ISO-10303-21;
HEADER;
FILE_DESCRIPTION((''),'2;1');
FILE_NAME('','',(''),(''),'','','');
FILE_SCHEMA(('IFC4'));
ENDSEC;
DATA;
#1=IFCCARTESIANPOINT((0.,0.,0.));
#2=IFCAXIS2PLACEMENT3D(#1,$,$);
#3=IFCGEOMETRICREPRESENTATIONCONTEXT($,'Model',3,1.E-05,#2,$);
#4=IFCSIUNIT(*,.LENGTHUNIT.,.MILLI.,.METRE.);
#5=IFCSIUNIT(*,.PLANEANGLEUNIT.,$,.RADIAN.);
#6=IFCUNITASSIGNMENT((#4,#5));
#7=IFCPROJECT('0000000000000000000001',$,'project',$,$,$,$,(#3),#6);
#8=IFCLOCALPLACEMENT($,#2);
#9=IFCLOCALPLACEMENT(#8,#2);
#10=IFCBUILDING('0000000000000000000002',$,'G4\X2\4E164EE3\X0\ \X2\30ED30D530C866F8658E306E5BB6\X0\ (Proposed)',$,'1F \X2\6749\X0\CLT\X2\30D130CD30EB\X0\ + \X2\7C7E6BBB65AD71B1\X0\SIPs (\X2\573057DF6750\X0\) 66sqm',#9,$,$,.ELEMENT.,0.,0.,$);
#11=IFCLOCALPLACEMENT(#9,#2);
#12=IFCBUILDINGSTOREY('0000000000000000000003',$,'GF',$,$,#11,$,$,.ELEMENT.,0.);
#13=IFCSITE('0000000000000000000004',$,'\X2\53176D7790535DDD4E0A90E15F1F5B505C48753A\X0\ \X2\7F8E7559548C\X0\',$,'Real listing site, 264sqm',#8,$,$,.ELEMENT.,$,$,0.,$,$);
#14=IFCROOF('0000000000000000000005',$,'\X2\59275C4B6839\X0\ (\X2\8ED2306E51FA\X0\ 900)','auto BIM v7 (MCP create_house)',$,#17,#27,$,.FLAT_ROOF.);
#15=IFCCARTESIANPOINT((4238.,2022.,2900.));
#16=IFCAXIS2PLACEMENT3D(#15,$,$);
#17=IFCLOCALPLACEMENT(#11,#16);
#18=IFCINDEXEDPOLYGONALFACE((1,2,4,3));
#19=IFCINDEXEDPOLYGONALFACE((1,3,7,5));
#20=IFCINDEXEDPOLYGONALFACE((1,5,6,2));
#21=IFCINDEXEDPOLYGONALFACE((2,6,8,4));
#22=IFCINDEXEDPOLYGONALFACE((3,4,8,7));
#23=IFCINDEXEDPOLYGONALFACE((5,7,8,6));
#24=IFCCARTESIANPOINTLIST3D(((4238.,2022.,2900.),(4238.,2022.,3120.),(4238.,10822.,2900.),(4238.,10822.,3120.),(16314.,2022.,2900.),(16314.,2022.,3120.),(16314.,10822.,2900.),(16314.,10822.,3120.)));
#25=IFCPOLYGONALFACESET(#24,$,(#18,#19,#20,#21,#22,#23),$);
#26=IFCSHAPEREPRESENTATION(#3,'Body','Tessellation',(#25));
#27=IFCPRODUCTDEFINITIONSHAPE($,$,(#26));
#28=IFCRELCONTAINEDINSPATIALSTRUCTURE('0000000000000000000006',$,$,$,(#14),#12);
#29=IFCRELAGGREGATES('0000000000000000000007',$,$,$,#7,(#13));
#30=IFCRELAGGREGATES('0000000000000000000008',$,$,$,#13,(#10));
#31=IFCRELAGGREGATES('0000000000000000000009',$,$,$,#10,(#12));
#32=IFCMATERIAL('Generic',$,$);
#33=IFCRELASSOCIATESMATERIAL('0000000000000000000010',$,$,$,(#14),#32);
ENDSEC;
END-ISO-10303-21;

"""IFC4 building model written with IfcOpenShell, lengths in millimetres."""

from ifc_helpers import new_model, si_unit, frame, frame_2d, origin, place, context, project, spatial, rectangle, extrude, material, element, save


model = new_model("IFC4")

# Units and contexts
model_context = context("Model", 3, precision=1e-05, world=origin())
ifc_project = project(units=[si_unit("LENGTHUNIT", "METRE", prefix="MILLI"), si_unit("PLANEANGLEUNIT", "RADIAN")], contexts=[model_context])

# Site, building, storey
site_placement = place(None, origin())
site = spatial("IfcSite", under=ifc_project, at=site_placement, Name="北海道川上郡弟子屈町 美留和", ObjectType="Real listing site, 264sqm", CompositionType="ELEMENT", RefElevation=0.0)
building_placement = place(site_placement, origin())
building = spatial("IfcBuilding", under=site, at=building_placement, Name="G4世代 ロフト書斎の家 (Proposed)", ObjectType="1F 杉CLTパネル + 籾殻断熱SIPs (地域材) 66sqm", CompositionType="ELEMENT", ElevationOfRefHeight=0.0, ElevationOfTerrain=0.0)
storey_placement = place(building_placement, origin())
storey = spatial("IfcBuildingStorey", under=building, at=storey_placement, Name="GF", CompositionType="ELEMENT", Elevation=0.0)

# Shared definitions
ifc_material = material(Name="Generic")

# Roof
roof_placement = place(storey_placement, frame((4238.0, 2022.0, 2900.0)))
element("IfcRoof", 1, at=roof_placement, inside=storey, material=ifc_material, Name="大屋根 (軒の出 900)", Description="auto BIM v7 (MCP create_house)", PredefinedType="FLAT_ROOF", context=model_context, shape_type="SweptSolid", body=[
    extrude(rectangle(XDim=12076.0, YDim=8800.0, at=frame_2d((6038.0, 4400.0))), frame((4238.0, 2022.0, 2900.0)), (0.0, 0.0, 1.0), 220.0),
])

save(model, "model.ifc")
